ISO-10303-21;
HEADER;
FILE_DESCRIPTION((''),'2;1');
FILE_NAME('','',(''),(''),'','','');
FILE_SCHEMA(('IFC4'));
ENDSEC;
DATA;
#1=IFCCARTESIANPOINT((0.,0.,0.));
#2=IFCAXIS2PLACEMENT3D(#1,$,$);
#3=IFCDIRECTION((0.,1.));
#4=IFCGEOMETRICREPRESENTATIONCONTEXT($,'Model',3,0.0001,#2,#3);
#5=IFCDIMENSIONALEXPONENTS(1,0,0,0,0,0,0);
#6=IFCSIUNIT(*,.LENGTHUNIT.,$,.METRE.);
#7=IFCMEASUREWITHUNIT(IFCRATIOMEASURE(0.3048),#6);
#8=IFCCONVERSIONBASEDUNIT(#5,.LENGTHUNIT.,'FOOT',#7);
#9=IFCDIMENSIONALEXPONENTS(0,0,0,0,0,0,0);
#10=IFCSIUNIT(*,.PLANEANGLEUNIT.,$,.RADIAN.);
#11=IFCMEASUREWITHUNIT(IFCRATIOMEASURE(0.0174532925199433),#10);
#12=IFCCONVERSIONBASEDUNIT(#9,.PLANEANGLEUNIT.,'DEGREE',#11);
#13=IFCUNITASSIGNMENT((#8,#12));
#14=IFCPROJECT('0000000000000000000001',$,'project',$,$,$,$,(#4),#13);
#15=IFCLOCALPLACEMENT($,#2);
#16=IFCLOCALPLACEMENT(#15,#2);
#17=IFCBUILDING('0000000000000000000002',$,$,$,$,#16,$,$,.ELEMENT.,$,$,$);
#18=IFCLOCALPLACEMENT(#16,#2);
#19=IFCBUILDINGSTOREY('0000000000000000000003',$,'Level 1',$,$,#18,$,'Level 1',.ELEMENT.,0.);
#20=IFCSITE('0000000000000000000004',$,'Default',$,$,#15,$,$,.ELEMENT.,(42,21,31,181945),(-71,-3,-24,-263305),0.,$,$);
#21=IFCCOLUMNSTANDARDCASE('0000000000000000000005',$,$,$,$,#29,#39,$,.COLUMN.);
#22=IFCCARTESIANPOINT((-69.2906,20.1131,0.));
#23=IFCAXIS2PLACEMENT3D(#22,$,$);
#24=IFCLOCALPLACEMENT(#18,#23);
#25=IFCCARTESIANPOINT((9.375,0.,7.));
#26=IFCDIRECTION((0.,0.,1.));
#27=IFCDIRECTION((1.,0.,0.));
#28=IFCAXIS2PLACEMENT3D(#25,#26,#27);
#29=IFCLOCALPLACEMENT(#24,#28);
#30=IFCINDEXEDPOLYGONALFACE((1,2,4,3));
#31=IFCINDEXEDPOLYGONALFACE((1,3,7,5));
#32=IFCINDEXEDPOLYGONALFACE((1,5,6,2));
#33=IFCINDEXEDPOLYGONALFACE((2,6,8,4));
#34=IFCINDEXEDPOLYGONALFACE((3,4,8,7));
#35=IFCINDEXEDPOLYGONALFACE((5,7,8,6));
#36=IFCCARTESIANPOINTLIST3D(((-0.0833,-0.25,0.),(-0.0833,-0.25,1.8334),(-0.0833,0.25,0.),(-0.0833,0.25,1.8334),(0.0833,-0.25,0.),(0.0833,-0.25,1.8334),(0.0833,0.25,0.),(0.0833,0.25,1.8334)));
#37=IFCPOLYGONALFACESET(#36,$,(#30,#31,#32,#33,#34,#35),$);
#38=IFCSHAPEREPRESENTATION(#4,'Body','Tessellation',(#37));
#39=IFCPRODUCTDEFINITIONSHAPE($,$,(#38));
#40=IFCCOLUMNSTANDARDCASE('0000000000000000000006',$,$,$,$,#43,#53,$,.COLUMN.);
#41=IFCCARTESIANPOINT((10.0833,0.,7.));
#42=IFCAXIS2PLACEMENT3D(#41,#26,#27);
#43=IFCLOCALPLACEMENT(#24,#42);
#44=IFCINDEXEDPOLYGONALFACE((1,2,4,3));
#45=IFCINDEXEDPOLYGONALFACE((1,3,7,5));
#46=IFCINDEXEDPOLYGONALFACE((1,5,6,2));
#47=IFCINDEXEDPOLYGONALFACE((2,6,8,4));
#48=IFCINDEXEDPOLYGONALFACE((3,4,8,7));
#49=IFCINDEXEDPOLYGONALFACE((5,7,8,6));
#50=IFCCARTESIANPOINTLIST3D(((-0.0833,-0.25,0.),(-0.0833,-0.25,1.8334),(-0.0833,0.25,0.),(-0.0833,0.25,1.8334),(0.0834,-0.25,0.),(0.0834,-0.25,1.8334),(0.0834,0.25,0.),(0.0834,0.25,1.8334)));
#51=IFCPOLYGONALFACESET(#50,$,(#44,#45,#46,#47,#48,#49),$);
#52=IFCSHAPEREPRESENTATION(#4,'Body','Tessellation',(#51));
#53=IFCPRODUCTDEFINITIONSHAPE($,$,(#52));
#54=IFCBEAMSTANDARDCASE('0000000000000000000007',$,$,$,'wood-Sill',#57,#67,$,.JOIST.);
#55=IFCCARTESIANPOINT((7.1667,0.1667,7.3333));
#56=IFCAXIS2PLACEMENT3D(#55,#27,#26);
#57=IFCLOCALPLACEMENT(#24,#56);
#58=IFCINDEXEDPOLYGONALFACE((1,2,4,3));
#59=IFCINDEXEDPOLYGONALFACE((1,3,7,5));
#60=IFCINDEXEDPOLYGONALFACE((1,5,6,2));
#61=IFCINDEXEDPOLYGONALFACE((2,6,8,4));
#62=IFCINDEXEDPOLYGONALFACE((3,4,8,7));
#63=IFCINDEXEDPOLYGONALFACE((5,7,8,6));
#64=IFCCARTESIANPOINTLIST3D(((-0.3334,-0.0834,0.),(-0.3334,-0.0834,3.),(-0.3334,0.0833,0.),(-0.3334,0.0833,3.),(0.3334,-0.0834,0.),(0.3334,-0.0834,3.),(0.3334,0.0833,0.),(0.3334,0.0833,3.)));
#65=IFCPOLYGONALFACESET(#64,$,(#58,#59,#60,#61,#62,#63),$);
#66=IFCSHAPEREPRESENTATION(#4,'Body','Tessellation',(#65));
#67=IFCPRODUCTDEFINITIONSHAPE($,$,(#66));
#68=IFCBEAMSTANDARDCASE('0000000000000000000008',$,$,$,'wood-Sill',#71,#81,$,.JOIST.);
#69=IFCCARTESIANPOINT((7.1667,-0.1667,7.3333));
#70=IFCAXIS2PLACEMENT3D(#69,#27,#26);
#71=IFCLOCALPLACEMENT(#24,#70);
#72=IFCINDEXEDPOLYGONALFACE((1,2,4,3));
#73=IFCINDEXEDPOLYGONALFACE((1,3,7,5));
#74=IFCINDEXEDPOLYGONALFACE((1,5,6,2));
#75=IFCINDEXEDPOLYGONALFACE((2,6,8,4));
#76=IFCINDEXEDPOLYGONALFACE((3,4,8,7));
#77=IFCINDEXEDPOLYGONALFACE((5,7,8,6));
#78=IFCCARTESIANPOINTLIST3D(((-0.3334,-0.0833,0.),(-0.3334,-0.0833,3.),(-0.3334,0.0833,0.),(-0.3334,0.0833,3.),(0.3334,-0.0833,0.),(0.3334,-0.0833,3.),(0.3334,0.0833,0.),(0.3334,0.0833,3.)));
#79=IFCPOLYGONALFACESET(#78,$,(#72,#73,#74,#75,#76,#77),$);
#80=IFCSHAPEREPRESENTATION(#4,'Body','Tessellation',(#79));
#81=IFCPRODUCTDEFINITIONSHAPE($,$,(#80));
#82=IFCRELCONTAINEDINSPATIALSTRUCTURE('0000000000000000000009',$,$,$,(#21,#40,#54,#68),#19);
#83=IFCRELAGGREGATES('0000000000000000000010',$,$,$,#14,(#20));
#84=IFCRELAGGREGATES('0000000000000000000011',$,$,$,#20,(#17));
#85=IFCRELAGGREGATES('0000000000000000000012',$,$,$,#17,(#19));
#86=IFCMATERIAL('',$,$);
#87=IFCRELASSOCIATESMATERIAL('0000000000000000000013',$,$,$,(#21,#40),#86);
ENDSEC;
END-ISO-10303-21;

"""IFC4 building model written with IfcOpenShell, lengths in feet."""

from ifc_helpers import new_model, entity, si_unit, converted_unit, direction, frame, origin, origin_with_axes, place, context, project, spatial, rectangle, extrude, material, element, save


model = new_model("IFC4")

# Units and contexts
model_context = context("Model", 3, precision=0.0001, world=origin(), true_north=direction((0.0, 1.0)))
ifc_project = project(units=[converted_unit("LENGTHUNIT", "FOOT", entity("IfcRatioMeasure", 0.3048), si_unit("LENGTHUNIT", "METRE"), dimensions=[1, 0, 0, 0, 0, 0, 0]), converted_unit("PLANEANGLEUNIT", "DEGREE", entity("IfcRatioMeasure", 0.0174532925199433), si_unit("PLANEANGLEUNIT", "RADIAN"), dimensions=[0, 0, 0, 0, 0, 0, 0])], contexts=[model_context])

# Site, building, storey
site_placement = place(None, origin())
site = spatial("IfcSite", under=ifc_project, at=site_placement, Name="Default", CompositionType="ELEMENT", RefLatitude=(42, 21, 31, 181945), RefLongitude=(-71, -3, -24, -263305), RefElevation=0.0)
building_placement = place(site_placement, origin())
building = spatial("IfcBuilding", under=site, at=building_placement, CompositionType="ELEMENT")
storey_placement = place(building_placement, origin())
storey = spatial("IfcBuildingStorey", under=building, at=storey_placement, Name="Level 1", LongName="Level 1", CompositionType="ELEMENT", Elevation=0.0)

# Columns
placement_1 = place(storey_placement, frame((-69.2906, 20.1131, 0.0)))
ifc_material_1 = material(Name="")
for number, where, z_axis, x_axis in (
    (1, (9.375, 0.0, 7.0), (0.0, 0.0, 1.0), (1.0, 0.0, 0.0)),
    (2, (10.0833, 0.0, 7.0), (0.0, 0.0, 1.0), (1.0, 0.0, 0.0)),
):
    element("IfcColumnStandardCase", number, at=place(placement_1, frame(where, z_axis=z_axis, x_axis=x_axis)), inside=storey, material=ifc_material_1, PredefinedType="COLUMN", context=model_context, shape_type="SweptSolid", body=[
        extrude(rectangle(XDim=0.1667, YDim=0.5), origin(), (0.0, 0.0, 1.0), 1.8334),
    ])

# Beams
for number, where, z_axis, x_axis in (
    (3, (7.1667, 0.1667, 7.3333), (1.0, 0.0, 0.0), (0.0, 0.0, 1.0)),
    (4, (7.1667, -0.1667, 7.3333), (1.0, 0.0, 0.0), (0.0, 0.0, 1.0)),
):
    element("IfcBeamStandardCase", number, at=place(placement_1, frame(where, z_axis=z_axis, x_axis=x_axis)), inside=storey, ObjectType="wood-Sill", PredefinedType="JOIST", context=model_context, shape_type="SweptSolid", body=[
        extrude(rectangle(XDim=0.6667, YDim=0.1667), origin_with_axes(), (0.0, 0.0, 1.0), 3.0),
    ])

save(model, "model.ifc")
